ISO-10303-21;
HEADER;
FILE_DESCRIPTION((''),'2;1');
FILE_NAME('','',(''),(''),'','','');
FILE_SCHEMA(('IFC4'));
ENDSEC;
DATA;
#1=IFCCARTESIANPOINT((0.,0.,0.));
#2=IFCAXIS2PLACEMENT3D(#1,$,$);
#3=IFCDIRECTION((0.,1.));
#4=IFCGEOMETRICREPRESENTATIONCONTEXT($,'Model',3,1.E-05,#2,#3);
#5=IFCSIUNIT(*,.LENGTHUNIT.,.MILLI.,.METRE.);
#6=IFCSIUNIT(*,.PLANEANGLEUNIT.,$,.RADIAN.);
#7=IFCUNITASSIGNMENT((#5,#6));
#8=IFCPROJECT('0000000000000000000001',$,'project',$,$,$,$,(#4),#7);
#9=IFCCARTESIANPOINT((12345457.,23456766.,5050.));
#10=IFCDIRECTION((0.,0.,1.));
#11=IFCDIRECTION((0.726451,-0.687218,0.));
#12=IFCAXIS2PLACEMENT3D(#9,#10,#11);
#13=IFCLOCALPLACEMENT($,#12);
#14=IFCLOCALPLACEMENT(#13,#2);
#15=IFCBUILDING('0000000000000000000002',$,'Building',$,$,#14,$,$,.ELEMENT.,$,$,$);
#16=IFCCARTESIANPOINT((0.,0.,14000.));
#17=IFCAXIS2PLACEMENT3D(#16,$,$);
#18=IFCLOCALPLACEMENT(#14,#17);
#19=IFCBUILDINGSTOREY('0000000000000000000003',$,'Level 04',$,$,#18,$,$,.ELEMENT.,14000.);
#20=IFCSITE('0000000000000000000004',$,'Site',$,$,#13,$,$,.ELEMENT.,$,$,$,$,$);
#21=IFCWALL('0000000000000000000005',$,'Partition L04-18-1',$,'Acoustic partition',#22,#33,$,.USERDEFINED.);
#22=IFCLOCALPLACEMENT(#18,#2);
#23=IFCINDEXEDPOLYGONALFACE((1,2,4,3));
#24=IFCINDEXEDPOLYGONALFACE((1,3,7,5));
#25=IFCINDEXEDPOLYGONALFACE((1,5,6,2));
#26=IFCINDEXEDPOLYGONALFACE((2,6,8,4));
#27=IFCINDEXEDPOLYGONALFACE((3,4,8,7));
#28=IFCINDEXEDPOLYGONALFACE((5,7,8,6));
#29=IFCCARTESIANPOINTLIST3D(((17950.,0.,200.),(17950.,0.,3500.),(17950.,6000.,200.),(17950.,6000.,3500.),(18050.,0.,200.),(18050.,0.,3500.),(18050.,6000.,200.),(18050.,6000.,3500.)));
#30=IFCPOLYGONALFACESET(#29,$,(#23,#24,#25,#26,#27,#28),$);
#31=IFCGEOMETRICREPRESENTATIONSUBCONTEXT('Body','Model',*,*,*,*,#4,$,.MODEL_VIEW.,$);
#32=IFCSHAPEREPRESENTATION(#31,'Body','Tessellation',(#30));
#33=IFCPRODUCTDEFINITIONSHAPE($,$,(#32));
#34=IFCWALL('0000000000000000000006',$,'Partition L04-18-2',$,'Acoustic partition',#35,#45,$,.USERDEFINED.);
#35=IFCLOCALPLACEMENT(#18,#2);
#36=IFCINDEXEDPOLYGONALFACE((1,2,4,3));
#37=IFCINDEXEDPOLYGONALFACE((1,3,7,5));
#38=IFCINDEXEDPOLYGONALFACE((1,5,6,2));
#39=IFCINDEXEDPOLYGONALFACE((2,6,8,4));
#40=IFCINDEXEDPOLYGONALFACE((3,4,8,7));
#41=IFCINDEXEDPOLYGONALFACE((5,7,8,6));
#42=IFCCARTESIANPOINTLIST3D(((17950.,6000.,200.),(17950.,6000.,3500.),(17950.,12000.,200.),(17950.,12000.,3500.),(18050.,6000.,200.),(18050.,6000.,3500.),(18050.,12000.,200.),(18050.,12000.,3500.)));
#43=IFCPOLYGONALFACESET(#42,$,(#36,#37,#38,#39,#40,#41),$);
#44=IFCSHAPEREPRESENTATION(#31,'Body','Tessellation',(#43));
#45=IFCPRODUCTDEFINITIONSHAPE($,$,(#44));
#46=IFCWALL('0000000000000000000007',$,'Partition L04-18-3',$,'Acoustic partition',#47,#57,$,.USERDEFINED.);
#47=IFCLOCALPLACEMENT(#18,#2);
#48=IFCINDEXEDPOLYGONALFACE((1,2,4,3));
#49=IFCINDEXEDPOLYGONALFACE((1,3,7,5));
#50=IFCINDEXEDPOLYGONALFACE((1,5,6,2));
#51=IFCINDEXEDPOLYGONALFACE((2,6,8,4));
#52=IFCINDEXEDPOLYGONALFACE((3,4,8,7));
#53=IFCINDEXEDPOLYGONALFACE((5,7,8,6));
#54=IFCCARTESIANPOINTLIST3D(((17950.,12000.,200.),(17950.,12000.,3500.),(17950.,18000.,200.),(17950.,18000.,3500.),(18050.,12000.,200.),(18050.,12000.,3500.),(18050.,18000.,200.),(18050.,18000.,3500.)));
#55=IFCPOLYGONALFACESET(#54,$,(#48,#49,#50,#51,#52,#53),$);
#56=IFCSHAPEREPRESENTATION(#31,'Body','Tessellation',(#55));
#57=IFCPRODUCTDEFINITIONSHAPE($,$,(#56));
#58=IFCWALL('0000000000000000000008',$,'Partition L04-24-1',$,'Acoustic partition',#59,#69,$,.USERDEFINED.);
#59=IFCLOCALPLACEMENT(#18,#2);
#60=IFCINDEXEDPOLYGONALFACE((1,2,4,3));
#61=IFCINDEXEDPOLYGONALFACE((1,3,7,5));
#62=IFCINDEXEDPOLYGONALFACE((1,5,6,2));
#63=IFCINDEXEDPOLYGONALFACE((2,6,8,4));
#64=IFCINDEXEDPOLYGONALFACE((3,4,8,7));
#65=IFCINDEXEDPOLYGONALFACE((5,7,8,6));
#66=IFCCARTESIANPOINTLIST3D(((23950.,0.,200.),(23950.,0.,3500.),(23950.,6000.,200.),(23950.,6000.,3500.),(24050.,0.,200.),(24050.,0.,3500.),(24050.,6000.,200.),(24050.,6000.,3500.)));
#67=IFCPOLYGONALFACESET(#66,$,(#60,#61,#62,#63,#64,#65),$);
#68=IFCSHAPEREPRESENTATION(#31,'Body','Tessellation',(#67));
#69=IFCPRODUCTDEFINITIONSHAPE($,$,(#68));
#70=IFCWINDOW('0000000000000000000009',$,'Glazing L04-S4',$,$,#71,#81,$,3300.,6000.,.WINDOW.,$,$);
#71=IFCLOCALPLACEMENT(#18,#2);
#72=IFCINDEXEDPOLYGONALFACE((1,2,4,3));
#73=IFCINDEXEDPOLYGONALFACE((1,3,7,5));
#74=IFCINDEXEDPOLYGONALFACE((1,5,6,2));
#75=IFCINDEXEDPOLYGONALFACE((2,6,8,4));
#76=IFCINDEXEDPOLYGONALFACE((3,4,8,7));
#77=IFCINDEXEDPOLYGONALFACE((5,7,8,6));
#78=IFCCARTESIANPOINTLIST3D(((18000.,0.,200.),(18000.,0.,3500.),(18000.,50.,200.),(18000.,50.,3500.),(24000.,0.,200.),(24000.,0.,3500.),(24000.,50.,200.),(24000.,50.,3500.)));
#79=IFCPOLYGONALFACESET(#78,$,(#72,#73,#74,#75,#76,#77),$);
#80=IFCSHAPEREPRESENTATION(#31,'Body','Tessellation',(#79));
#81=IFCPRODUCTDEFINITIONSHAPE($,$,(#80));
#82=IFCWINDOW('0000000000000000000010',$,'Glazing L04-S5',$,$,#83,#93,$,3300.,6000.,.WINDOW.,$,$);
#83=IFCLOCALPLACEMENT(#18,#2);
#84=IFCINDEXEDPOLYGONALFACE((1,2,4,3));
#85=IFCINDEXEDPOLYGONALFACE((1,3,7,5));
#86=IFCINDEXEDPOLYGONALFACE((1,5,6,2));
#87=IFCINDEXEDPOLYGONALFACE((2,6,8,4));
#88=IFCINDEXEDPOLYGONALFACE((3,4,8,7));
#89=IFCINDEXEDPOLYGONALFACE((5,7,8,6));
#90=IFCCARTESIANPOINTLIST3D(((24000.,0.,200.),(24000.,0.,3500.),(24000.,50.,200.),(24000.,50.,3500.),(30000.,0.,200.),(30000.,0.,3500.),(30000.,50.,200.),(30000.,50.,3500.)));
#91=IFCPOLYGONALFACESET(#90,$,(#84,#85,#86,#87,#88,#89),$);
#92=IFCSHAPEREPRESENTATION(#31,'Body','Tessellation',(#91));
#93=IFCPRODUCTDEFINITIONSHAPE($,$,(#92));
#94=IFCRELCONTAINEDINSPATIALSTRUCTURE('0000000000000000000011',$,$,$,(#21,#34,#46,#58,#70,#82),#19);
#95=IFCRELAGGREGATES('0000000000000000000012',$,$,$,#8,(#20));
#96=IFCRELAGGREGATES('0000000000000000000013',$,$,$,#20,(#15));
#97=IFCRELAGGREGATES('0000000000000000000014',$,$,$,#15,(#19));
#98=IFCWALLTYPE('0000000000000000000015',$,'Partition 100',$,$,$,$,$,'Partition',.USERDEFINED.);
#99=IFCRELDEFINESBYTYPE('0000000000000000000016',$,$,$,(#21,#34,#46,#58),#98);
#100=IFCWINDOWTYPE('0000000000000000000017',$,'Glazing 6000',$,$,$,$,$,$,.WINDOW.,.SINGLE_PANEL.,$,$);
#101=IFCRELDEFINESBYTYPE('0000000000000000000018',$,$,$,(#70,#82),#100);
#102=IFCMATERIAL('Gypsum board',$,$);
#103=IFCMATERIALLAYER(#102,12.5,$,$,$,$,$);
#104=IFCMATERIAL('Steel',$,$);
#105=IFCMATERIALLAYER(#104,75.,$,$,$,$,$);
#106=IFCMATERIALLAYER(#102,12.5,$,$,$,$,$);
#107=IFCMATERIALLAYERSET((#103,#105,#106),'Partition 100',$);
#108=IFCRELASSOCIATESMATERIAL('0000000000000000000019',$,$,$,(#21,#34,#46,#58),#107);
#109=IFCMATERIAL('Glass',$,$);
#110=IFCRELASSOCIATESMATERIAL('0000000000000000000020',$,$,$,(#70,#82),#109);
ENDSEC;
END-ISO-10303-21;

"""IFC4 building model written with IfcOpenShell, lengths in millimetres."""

from ifc_helpers import new_model, si_unit, direction, frame, origin, place, context, subcontext, project, spatial, rectangle, extrude, material, layer, layer_set, layer_usage, type_object, element, save


model = new_model("IFC4")

# Units and contexts
model_context = context("Model", 3, precision=1e-05, world=origin(), true_north=direction((0.0, 1.0)))
body_context = subcontext(model_context, "Body", "Model", "MODEL_VIEW")
ifc_project = project(units=[si_unit("LENGTHUNIT", "METRE", prefix="MILLI"), si_unit("PLANEANGLEUNIT", "RADIAN")], contexts=[model_context])

# Site, building, storey
site_placement = place(None, frame((12345457.0, 23456766.0, 5050.0), z_axis=(0.0, 0.0, 1.0), x_axis=(0.726451, -0.687218, 0.0)))
site = spatial("IfcSite", under=ifc_project, at=site_placement, Name="Site", CompositionType="ELEMENT")
building_placement = place(site_placement, origin())
building = spatial("IfcBuilding", under=site, at=building_placement, Name="Building", CompositionType="ELEMENT")
storey_placement = place(building_placement, frame((0.0, 0.0, 14000.0)))
storey = spatial("IfcBuildingStorey", under=building, at=storey_placement, Name="Level 04", CompositionType="ELEMENT", Elevation=14000.0)

# Shared definitions
ifc_material_1 = material(Name="Steel")

# Walls
ifc_material_2 = material(Name="Gypsum board")
ifc_layer_1 = layer(ifc_material_2, 12.5)
ifc_layer_2 = layer(ifc_material_1, 75.0)
ifc_layer_3 = layer(ifc_material_2, 12.5)
ifc_layer_set = layer_set([ifc_layer_1, ifc_layer_2, ifc_layer_3], Name="Partition 100")
ifc_layer_usage = layer_usage(ifc_layer_set, "AXIS2", "POSITIVE", 0.0)
wall_type = type_object("IfcWallType", Name="Partition 100", ElementType="Partition", PredefinedType="USERDEFINED")
for number, where, name in (
    (1, (17950.0, 0.0, 200.0), "Partition L04-18-1"),
    (2, (17950.0, 6000.0, 200.0), "Partition L04-18-2"),
    (3, (17950.0, 12000.0, 200.0), "Partition L04-18-3"),
    (4, (23950.0, 0.0, 200.0), "Partition L04-24-1"),
):
    element("IfcWall", number, at=place(storey_placement, frame(where)), inside=storey, type_object=wall_type, material=ifc_layer_usage, Name=name, ObjectType="Acoustic partition", PredefinedType="USERDEFINED", context=body_context, shape_type="SweptSolid", body=[
        extrude(rectangle(XDim=100.0, YDim=6000.0), frame((50.0, 3000.0, 0.0)), (0.0, 0.0, 1.0), 3300.0),
    ])

# Windows
ifc_material_3 = material(Name="Glass")
window_type = type_object("IfcWindowType", Name="Glazing 6000", PartitioningType="SINGLE_PANEL", PredefinedType="WINDOW")
for number, where, name in (
    (5, (18000.0, 0.0, 200.0), "Glazing L04-S4"),
    (6, (24000.0, 0.0, 200.0), "Glazing L04-S5"),
):
    element("IfcWindow", number, at=place(storey_placement, frame(where)), inside=storey, type_object=window_type, material=ifc_material_3, Name=name, OverallHeight=3300.0, OverallWidth=6000.0, PredefinedType="WINDOW", context=body_context, shape_type="SweptSolid", body=[
        extrude(rectangle(XDim=6000.0, YDim=50.0), frame((3000.0, 25.0, 0.0)), (0.0, 0.0, 1.0), 3300.0),
    ])

save(model, "model.ifc")
